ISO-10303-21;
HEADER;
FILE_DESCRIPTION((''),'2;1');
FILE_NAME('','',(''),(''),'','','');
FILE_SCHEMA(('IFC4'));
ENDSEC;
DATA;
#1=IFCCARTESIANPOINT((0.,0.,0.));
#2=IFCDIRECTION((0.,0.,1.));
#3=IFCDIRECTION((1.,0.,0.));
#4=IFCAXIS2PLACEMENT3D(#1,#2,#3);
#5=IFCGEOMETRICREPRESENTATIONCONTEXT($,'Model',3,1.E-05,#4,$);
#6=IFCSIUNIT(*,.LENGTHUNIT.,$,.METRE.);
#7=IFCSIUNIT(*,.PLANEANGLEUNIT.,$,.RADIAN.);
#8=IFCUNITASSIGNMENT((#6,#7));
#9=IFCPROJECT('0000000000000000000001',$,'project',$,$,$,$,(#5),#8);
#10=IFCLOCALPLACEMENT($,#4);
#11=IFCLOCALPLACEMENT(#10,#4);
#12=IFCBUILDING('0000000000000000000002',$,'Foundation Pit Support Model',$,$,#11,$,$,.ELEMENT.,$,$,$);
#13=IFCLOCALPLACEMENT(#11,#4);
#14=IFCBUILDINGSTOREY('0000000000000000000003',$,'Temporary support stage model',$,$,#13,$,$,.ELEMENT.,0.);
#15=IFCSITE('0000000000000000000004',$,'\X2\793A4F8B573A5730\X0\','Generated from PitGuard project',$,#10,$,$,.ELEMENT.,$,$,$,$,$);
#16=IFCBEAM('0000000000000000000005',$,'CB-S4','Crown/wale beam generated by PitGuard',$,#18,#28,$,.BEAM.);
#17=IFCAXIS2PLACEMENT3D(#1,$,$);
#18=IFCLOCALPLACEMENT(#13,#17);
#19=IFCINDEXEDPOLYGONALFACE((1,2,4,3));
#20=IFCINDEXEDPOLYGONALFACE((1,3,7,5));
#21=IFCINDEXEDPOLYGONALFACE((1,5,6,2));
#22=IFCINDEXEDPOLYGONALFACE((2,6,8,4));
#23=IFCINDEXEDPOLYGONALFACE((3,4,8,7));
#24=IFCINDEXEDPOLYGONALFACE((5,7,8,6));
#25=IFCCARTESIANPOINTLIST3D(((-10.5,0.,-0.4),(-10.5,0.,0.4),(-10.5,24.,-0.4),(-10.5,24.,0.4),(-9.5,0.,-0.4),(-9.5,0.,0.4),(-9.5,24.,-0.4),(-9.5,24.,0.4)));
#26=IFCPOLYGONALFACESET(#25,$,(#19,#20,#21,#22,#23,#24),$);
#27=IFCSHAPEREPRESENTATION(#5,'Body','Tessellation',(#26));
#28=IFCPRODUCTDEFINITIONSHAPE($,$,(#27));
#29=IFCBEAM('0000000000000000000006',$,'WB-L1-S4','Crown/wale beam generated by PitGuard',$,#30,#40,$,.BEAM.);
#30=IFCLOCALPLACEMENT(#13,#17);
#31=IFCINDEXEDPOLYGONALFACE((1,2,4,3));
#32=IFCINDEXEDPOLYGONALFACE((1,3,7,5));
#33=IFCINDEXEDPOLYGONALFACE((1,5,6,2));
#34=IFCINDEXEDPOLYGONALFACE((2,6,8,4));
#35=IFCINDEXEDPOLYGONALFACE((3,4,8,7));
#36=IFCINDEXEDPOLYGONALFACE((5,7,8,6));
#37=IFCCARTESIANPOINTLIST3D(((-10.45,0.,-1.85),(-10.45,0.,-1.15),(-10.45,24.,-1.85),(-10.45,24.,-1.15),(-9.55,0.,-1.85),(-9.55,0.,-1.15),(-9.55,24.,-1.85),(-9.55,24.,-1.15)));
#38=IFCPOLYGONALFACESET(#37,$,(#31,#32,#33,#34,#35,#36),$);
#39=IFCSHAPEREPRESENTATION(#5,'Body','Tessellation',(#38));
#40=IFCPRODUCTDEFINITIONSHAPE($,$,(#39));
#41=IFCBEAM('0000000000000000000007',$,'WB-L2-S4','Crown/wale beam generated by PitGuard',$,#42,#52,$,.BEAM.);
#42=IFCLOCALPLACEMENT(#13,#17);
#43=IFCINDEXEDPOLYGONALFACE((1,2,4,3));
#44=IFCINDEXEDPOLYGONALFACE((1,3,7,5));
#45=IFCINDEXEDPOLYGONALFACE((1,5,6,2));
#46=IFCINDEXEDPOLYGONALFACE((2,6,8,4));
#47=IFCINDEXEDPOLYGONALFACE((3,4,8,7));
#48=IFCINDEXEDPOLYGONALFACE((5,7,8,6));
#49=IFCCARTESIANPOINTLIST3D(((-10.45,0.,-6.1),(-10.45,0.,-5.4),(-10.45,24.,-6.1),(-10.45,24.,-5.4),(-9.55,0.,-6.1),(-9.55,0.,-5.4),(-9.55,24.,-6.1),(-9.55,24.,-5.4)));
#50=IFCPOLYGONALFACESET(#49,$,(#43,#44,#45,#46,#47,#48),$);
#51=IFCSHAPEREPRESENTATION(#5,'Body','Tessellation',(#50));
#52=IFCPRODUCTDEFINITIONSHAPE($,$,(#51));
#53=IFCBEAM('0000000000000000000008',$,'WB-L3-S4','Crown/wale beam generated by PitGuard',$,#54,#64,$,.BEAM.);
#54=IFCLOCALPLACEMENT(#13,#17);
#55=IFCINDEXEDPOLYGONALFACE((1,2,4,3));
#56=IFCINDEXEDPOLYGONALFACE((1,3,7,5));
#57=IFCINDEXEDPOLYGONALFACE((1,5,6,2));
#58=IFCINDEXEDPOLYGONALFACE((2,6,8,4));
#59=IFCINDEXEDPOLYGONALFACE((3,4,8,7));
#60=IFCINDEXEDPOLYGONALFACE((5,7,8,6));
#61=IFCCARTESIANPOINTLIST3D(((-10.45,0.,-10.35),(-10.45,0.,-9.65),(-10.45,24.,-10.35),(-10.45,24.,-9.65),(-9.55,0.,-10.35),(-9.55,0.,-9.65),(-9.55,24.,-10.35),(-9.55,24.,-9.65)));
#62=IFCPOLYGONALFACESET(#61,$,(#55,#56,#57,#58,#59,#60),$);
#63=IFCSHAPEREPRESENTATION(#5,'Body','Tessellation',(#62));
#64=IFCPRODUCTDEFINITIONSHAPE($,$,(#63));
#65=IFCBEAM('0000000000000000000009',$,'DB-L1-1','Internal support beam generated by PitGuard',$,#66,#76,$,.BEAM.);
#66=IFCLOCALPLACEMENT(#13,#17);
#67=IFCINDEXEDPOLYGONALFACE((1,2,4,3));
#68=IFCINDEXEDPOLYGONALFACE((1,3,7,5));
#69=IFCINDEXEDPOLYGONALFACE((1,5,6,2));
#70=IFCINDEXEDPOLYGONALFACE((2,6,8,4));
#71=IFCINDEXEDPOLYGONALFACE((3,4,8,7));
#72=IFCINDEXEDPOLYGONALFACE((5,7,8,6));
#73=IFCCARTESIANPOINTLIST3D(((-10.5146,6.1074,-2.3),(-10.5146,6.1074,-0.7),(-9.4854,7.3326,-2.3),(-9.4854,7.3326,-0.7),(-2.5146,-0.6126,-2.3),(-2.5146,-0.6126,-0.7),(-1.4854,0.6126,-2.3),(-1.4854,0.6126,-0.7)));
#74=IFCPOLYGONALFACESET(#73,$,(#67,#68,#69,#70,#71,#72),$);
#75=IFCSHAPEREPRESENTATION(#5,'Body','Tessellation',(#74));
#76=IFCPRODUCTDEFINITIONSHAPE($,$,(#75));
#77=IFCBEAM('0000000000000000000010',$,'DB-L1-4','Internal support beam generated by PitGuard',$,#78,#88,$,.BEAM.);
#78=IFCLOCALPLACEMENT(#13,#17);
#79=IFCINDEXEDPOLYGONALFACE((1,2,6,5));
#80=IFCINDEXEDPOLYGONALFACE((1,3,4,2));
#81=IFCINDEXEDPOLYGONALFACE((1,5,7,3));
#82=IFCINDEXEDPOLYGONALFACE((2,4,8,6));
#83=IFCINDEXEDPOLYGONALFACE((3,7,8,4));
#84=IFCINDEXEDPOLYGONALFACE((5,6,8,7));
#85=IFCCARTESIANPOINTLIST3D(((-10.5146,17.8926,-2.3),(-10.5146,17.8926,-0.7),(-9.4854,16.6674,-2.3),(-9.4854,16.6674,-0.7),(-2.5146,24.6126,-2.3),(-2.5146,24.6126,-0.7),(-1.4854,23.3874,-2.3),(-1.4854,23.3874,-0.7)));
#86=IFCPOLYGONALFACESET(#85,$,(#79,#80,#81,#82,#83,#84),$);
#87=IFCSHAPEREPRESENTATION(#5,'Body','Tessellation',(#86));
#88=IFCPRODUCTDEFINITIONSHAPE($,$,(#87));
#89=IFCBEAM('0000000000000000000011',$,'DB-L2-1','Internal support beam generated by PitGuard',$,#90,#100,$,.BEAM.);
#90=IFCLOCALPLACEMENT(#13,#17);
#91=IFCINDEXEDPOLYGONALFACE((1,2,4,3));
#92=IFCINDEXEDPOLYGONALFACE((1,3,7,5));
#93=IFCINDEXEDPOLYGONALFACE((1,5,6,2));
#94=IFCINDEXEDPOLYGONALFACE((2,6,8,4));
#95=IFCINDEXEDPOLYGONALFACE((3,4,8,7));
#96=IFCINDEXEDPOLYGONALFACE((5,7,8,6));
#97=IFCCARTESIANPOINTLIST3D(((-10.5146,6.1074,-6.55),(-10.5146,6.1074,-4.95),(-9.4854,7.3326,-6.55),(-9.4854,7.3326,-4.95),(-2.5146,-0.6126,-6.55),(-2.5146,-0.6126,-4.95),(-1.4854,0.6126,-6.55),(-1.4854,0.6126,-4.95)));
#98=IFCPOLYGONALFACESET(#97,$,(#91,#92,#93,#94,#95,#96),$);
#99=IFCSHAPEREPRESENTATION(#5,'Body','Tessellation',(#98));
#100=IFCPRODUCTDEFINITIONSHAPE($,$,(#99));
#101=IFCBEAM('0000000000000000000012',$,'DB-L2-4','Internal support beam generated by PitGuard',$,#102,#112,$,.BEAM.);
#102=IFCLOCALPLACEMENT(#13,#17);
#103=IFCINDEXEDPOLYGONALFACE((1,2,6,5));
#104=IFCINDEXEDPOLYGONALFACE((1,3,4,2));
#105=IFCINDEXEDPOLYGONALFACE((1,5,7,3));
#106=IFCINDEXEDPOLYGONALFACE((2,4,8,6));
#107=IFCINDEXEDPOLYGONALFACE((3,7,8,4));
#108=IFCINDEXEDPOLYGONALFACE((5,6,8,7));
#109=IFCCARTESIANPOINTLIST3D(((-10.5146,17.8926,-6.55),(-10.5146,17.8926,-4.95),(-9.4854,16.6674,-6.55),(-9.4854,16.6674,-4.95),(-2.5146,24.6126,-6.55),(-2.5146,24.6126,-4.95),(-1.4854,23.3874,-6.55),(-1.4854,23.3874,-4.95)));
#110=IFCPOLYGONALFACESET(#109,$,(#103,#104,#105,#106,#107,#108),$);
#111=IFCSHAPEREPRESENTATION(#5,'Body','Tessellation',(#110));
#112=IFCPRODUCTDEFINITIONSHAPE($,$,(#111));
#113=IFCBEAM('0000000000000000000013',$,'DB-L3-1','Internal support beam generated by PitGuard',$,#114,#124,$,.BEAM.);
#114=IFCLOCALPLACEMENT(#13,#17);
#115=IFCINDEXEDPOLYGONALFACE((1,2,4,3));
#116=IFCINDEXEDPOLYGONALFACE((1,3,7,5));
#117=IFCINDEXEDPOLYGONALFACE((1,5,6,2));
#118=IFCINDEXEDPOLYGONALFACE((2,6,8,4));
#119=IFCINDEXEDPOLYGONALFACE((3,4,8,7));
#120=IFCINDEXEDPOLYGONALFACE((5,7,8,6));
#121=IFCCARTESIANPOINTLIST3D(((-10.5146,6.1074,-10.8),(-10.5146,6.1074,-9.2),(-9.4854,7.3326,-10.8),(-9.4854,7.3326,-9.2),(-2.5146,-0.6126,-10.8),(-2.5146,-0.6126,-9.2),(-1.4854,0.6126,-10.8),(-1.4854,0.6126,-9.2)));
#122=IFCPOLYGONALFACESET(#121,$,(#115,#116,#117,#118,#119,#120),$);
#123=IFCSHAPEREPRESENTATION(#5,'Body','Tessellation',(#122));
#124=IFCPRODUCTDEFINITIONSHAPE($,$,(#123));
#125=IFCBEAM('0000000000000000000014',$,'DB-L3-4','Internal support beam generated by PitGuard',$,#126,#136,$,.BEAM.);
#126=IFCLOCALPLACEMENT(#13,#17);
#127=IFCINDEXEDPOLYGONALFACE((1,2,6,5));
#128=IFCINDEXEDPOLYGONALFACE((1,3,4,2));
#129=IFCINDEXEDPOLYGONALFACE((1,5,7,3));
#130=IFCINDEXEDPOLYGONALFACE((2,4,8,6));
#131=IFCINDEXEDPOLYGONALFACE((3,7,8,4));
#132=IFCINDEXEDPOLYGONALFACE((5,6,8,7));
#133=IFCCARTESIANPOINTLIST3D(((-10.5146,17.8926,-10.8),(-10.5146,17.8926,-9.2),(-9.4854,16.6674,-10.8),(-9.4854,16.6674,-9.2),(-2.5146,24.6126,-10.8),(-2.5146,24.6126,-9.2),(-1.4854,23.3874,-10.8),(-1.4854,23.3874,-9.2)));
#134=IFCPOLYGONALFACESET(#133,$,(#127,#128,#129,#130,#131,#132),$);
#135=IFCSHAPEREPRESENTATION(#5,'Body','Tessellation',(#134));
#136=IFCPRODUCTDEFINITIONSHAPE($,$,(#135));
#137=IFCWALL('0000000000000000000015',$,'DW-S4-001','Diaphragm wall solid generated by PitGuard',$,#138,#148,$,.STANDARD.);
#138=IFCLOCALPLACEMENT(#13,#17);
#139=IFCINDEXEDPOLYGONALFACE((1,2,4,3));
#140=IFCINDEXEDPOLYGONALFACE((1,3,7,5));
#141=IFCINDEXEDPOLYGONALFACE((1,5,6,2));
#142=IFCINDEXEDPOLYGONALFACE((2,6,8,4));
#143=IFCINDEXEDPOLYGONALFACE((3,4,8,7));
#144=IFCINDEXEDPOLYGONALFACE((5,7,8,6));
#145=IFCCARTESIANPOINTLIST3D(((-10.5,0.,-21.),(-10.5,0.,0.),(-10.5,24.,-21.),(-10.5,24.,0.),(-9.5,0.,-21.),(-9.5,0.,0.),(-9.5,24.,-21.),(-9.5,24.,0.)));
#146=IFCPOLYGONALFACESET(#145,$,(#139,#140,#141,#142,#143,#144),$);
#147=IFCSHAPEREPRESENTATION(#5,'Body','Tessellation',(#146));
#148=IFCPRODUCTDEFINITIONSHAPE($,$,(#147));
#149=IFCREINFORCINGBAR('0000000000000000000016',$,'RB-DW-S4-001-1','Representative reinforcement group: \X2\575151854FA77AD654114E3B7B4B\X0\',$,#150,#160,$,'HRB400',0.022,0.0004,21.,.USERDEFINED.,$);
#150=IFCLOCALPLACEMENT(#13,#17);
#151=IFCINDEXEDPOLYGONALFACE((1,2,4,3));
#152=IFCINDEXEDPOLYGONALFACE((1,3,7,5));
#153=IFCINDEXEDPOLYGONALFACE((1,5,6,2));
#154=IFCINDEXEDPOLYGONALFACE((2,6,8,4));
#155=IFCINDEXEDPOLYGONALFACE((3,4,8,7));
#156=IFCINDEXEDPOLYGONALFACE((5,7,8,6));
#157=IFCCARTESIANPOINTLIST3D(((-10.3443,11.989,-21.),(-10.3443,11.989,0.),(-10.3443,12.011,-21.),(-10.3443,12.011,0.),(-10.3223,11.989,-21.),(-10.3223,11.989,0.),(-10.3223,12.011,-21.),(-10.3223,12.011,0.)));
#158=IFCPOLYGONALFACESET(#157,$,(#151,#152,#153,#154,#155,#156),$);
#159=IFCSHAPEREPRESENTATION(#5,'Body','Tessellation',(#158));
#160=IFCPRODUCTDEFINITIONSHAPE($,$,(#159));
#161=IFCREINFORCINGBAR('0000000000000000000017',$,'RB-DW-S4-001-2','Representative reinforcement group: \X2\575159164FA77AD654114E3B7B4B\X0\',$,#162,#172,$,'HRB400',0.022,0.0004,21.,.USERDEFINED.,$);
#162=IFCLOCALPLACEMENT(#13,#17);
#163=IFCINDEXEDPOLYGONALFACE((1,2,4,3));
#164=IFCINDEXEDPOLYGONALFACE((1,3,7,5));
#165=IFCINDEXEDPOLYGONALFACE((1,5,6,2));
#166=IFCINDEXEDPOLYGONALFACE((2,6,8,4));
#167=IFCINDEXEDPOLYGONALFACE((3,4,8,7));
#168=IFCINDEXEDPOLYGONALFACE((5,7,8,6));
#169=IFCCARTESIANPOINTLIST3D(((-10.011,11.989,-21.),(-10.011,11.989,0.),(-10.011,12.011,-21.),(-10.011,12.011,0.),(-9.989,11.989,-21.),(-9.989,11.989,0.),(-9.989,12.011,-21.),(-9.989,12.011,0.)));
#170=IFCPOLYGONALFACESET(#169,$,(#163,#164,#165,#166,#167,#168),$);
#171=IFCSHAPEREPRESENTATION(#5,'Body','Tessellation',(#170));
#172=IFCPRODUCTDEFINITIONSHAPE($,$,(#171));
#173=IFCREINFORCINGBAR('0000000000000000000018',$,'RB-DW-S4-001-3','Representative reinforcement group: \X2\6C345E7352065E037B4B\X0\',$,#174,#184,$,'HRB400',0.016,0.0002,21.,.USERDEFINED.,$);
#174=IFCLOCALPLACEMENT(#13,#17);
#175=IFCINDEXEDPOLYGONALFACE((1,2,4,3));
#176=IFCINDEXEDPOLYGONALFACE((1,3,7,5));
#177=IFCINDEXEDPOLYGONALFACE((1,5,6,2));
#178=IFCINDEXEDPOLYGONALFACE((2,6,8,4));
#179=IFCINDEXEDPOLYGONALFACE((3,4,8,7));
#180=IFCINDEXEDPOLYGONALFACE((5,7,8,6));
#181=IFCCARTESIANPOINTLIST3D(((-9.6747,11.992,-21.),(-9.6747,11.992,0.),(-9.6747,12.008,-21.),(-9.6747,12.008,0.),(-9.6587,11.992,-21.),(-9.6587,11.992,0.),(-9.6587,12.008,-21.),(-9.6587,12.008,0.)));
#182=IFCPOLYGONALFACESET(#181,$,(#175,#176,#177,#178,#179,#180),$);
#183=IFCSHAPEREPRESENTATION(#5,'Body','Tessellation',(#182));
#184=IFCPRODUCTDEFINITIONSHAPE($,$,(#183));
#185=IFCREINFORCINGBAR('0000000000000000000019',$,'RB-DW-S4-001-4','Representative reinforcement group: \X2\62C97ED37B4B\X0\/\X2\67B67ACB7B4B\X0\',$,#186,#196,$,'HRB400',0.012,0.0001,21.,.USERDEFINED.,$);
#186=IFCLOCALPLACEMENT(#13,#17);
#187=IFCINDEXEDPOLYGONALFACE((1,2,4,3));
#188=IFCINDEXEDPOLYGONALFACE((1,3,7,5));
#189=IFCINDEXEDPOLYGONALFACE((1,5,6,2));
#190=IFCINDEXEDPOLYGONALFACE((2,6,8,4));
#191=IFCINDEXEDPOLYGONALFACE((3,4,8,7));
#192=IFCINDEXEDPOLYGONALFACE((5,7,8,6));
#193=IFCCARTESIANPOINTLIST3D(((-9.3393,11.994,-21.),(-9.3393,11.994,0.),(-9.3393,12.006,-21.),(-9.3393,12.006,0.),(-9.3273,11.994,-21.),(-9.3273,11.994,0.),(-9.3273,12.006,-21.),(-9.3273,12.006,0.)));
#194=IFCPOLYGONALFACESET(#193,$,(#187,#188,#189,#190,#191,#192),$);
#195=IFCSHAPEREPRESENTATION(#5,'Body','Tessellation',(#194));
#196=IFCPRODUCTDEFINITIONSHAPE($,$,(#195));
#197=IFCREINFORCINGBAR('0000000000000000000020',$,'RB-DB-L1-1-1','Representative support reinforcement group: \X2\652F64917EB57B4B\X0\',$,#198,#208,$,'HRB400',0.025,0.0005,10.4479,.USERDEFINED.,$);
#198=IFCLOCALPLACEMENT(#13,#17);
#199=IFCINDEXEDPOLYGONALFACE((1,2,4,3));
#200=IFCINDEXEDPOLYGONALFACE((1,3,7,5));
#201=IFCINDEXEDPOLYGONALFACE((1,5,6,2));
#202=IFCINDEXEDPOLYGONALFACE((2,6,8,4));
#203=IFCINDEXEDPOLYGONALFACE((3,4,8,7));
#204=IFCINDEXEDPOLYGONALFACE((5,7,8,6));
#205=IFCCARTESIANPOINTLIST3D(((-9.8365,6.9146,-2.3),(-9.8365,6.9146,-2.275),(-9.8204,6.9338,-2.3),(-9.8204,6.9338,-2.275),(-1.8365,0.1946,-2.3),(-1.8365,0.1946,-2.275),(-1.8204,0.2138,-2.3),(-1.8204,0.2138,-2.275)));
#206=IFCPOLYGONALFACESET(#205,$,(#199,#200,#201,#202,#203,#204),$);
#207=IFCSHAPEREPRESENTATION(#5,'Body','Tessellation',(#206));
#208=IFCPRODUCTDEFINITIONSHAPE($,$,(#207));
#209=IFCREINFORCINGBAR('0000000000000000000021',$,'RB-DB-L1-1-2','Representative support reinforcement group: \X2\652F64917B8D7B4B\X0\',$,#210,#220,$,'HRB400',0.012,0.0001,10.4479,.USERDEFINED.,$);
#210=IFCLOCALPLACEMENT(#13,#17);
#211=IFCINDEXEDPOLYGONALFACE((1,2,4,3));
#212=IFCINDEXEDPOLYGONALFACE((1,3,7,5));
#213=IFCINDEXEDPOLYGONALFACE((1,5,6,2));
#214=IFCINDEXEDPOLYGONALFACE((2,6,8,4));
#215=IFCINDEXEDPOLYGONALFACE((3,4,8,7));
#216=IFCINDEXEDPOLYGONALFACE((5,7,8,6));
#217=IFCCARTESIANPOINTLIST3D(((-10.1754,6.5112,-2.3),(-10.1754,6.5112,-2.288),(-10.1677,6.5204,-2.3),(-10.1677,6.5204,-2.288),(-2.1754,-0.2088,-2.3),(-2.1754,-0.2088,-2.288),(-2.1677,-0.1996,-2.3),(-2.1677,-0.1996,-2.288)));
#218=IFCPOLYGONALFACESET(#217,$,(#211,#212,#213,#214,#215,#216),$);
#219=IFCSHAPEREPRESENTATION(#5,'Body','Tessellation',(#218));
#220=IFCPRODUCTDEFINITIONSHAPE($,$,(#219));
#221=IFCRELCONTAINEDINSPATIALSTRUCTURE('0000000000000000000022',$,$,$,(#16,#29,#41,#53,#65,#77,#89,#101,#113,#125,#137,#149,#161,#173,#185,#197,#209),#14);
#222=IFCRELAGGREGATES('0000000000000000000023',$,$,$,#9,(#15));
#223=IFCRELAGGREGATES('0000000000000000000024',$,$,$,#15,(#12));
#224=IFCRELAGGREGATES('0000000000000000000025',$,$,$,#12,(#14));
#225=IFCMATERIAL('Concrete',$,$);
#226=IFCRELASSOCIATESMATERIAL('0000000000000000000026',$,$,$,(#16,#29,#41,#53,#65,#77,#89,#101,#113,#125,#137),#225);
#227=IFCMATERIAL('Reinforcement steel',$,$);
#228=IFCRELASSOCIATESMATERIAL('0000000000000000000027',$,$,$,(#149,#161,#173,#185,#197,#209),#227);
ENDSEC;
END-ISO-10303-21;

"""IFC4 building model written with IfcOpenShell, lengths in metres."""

from ifc_helpers import new_model, si_unit, frame, origin_with_axes, origin_2d, place, context, project, spatial, rectangle, extrude, material, element, save


model = new_model("IFC4")

# Units and contexts
model_context = context("Model", 3, precision=1e-05, world=origin_with_axes())
ifc_project = project(units=[si_unit("LENGTHUNIT", "METRE"), si_unit("PLANEANGLEUNIT", "RADIAN")], contexts=[model_context])

# Site, building, storey
site_placement = place(None, origin_with_axes())
site = spatial("IfcSite", under=ifc_project, at=site_placement, Name="示例场地", Description="Generated from PitGuard project", CompositionType="ELEMENT")
building_placement = place(site_placement, origin_with_axes())
building = spatial("IfcBuilding", under=site, at=building_placement, Name="Foundation Pit Support Model", CompositionType="ELEMENT")
storey_placement = place(building_placement, origin_with_axes())
storey = spatial("IfcBuildingStorey", under=building, at=storey_placement, Name="Temporary support stage model", CompositionType="ELEMENT", Elevation=0.0)

# Beams
ifc_material_1 = material(Name="Concrete")
beam_placement = place(storey_placement, frame((-10.0, 12.0, -0.4), z_axis=(0.0, 0.0, 1.0), x_axis=(0.0, -1.0, 0.0)))
element("IfcBeam", 1, at=beam_placement, inside=storey, material=ifc_material_1, Name="CB-S4", Description="Crown/wale beam generated by PitGuard", PredefinedType="BEAM", context=model_context, shape_type="SweptSolid", body=[
    extrude(rectangle(XDim=24.0, YDim=1.0, at=origin_2d()), origin_with_axes(), (0.0, 0.0, 1.0), 0.8),
])
for number, where, z_axis, x_axis, name in (
    (2, (-10.0, 12.0, -1.85), (0.0, 0.0, 1.0), (0.0, -1.0, 0.0), "WB-L1-S4"),
    (3, (-10.0, 12.0, -6.1), (0.0, 0.0, 1.0), (0.0, -1.0, 0.0), "WB-L2-S4"),
    (4, (-10.0, 12.0, -10.35), (0.0, 0.0, 1.0), (0.0, -1.0, 0.0), "WB-L3-S4"),
):
    element("IfcBeam", number, at=place(storey_placement, frame(where, z_axis=z_axis, x_axis=x_axis)), inside=storey, material=ifc_material_1, Name=name, Description="Crown/wale beam generated by PitGuard", PredefinedType="BEAM", context=model_context, shape_type="SweptSolid", body=[
        extrude(rectangle(XDim=24.0, YDim=0.9, at=origin_2d()), origin_with_axes(), (0.0, 0.0, 1.0), 0.7),
    ])
for number, where, z_axis, x_axis, name in (
    (5, (-6.0, 3.36, -2.3), (0.0, 0.0, 1.0), (-0.765705, 0.643192, 0.0), "DB-L1-1"),
    (6, (-6.0, 20.64, -2.3), (0.0, 0.0, 1.0), (-0.765705, -0.643192, 0.0), "DB-L1-4"),
    (7, (-6.0, 3.36, -6.55), (0.0, 0.0, 1.0), (-0.765705, 0.643192, 0.0), "DB-L2-1"),
    (8, (-6.0, 20.64, -6.55), (0.0, 0.0, 1.0), (-0.765705, -0.643192, 0.0), "DB-L2-4"),
    (9, (-6.0, 3.36, -10.8), (0.0, 0.0, 1.0), (-0.765705, 0.643192, 0.0), "DB-L3-1"),
    (10, (-6.0, 20.64, -10.8), (0.0, 0.0, 1.0), (-0.765705, -0.643192, 0.0), "DB-L3-4"),
):
    element("IfcBeam", number, at=place(storey_placement, frame(where, z_axis=z_axis, x_axis=x_axis)), inside=storey, material=ifc_material_1, Name=name, Description="Internal support beam generated by PitGuard", PredefinedType="BEAM", context=model_context, shape_type="SweptSolid", body=[
        extrude(rectangle(XDim=10.4479, YDim=1.6, at=origin_2d()), origin_with_axes(), (0.0, 0.0, 1.0), 1.6),
    ])

# Wall
wall_placement = place(storey_placement, frame((-10.0, 12.0, -21.0), z_axis=(0.0, 0.0, 1.0), x_axis=(0.0, -1.0, 0.0)))
element("IfcWall", 11, at=wall_placement, inside=storey, material=ifc_material_1, Name="DW-S4-001", Description="Diaphragm wall solid generated by PitGuard", PredefinedType="STANDARD", context=model_context, shape_type="SweptSolid", body=[
    extrude(rectangle(XDim=24.0, YDim=1.0, at=origin_2d()), origin_with_axes(), (0.0, 0.0, 1.0), 21.0),
])

# Reinforcing bars
ifc_material_2 = material(Name="Reinforcement steel")
for number, where, z_axis, x_axis, name, description in (
    (12, (-10.3333, 12.0, -21.0), (0.0, 0.0, 1.0), (1.0, 0.0, 0.0), "RB-DW-S4-001-1", "Representative reinforcement group: 坑内侧竖向主筋"),
    (13, (-10.0, 12.0, -21.0), (0.0, 0.0, 1.0), (1.0, 0.0, 0.0), "RB-DW-S4-001-2", "Representative reinforcement group: 坑外侧竖向主筋"),
):
    element("IfcReinforcingBar", number, at=place(storey_placement, frame(where, z_axis=z_axis, x_axis=x_axis)), inside=storey, material=ifc_material_2, Name=name, Description=description, SteelGrade="HRB400", BarLength=21.0, CrossSectionArea=0.0004, NominalDiameter=0.022, PredefinedType="USERDEFINED", context=model_context, shape_type="SweptSolid", body=[
        extrude(rectangle(XDim=0.022, YDim=0.022, at=origin_2d()), origin_with_axes(), (0.0, 0.0, 1.0), 21.0),
    ])
reinforcing_bar_1_placement = place(storey_placement, frame((-9.6667, 12.0, -21.0), z_axis=(0.0, 0.0, 1.0), x_axis=(1.0, 0.0, 0.0)))
element("IfcReinforcingBar", 14, at=reinforcing_bar_1_placement, inside=storey, material=ifc_material_2, Name="RB-DW-S4-001-3", Description="Representative reinforcement group: 水平分布筋", SteelGrade="HRB400", BarLength=21.0, CrossSectionArea=0.0002, NominalDiameter=0.016, PredefinedType="USERDEFINED", context=model_context, shape_type="SweptSolid", body=[
    extrude(rectangle(XDim=0.016, YDim=0.016, at=origin_2d()), origin_with_axes(), (0.0, 0.0, 1.0), 21.0),
])
reinforcing_bar_2_placement = place(storey_placement, frame((-9.3333, 12.0, -21.0), z_axis=(0.0, 0.0, 1.0), x_axis=(1.0, 0.0, 0.0)))
element("IfcReinforcingBar", 15, at=reinforcing_bar_2_placement, inside=storey, material=ifc_material_2, Name="RB-DW-S4-001-4", Description="Representative reinforcement group: 拉结筋/架立筋", SteelGrade="HRB400", BarLength=21.0, CrossSectionArea=0.0001, NominalDiameter=0.012, PredefinedType="USERDEFINED", context=model_context, shape_type="SweptSolid", body=[
    extrude(rectangle(XDim=0.012, YDim=0.012, at=origin_2d()), origin_with_axes(), (0.0, 0.0, 1.0), 21.0),
])
reinforcing_bar_3_placement = place(storey_placement, frame((-5.8285, 3.5642, -2.3), z_axis=(0.0, 0.0, 1.0), x_axis=(-0.765705, 0.643192, 0.0)))
element("IfcReinforcingBar", 16, at=reinforcing_bar_3_placement, inside=storey, material=ifc_material_2, Name="RB-DB-L1-1-1", Description="Representative support reinforcement group: 支撑纵筋", SteelGrade="HRB400", BarLength=10.4479, CrossSectionArea=0.0005, NominalDiameter=0.025, PredefinedType="USERDEFINED", context=model_context, shape_type="SweptSolid", body=[
    extrude(rectangle(XDim=10.4479, YDim=0.025, at=origin_2d()), origin_with_axes(), (0.0, 0.0, 1.0), 0.025),
])
reinforcing_bar_4_placement = place(storey_placement, frame((-6.1715, 3.1558, -2.3), z_axis=(0.0, 0.0, 1.0), x_axis=(-0.765705, 0.643192, 0.0)))
element("IfcReinforcingBar", 17, at=reinforcing_bar_4_placement, inside=storey, material=ifc_material_2, Name="RB-DB-L1-1-2", Description="Representative support reinforcement group: 支撑箍筋", SteelGrade="HRB400", BarLength=10.4479, CrossSectionArea=0.0001, NominalDiameter=0.012, PredefinedType="USERDEFINED", context=model_context, shape_type="SweptSolid", body=[
    extrude(rectangle(XDim=10.4479, YDim=0.012, at=origin_2d()), origin_with_axes(), (0.0, 0.0, 1.0), 0.012),
])

save(model, "model.ifc")
